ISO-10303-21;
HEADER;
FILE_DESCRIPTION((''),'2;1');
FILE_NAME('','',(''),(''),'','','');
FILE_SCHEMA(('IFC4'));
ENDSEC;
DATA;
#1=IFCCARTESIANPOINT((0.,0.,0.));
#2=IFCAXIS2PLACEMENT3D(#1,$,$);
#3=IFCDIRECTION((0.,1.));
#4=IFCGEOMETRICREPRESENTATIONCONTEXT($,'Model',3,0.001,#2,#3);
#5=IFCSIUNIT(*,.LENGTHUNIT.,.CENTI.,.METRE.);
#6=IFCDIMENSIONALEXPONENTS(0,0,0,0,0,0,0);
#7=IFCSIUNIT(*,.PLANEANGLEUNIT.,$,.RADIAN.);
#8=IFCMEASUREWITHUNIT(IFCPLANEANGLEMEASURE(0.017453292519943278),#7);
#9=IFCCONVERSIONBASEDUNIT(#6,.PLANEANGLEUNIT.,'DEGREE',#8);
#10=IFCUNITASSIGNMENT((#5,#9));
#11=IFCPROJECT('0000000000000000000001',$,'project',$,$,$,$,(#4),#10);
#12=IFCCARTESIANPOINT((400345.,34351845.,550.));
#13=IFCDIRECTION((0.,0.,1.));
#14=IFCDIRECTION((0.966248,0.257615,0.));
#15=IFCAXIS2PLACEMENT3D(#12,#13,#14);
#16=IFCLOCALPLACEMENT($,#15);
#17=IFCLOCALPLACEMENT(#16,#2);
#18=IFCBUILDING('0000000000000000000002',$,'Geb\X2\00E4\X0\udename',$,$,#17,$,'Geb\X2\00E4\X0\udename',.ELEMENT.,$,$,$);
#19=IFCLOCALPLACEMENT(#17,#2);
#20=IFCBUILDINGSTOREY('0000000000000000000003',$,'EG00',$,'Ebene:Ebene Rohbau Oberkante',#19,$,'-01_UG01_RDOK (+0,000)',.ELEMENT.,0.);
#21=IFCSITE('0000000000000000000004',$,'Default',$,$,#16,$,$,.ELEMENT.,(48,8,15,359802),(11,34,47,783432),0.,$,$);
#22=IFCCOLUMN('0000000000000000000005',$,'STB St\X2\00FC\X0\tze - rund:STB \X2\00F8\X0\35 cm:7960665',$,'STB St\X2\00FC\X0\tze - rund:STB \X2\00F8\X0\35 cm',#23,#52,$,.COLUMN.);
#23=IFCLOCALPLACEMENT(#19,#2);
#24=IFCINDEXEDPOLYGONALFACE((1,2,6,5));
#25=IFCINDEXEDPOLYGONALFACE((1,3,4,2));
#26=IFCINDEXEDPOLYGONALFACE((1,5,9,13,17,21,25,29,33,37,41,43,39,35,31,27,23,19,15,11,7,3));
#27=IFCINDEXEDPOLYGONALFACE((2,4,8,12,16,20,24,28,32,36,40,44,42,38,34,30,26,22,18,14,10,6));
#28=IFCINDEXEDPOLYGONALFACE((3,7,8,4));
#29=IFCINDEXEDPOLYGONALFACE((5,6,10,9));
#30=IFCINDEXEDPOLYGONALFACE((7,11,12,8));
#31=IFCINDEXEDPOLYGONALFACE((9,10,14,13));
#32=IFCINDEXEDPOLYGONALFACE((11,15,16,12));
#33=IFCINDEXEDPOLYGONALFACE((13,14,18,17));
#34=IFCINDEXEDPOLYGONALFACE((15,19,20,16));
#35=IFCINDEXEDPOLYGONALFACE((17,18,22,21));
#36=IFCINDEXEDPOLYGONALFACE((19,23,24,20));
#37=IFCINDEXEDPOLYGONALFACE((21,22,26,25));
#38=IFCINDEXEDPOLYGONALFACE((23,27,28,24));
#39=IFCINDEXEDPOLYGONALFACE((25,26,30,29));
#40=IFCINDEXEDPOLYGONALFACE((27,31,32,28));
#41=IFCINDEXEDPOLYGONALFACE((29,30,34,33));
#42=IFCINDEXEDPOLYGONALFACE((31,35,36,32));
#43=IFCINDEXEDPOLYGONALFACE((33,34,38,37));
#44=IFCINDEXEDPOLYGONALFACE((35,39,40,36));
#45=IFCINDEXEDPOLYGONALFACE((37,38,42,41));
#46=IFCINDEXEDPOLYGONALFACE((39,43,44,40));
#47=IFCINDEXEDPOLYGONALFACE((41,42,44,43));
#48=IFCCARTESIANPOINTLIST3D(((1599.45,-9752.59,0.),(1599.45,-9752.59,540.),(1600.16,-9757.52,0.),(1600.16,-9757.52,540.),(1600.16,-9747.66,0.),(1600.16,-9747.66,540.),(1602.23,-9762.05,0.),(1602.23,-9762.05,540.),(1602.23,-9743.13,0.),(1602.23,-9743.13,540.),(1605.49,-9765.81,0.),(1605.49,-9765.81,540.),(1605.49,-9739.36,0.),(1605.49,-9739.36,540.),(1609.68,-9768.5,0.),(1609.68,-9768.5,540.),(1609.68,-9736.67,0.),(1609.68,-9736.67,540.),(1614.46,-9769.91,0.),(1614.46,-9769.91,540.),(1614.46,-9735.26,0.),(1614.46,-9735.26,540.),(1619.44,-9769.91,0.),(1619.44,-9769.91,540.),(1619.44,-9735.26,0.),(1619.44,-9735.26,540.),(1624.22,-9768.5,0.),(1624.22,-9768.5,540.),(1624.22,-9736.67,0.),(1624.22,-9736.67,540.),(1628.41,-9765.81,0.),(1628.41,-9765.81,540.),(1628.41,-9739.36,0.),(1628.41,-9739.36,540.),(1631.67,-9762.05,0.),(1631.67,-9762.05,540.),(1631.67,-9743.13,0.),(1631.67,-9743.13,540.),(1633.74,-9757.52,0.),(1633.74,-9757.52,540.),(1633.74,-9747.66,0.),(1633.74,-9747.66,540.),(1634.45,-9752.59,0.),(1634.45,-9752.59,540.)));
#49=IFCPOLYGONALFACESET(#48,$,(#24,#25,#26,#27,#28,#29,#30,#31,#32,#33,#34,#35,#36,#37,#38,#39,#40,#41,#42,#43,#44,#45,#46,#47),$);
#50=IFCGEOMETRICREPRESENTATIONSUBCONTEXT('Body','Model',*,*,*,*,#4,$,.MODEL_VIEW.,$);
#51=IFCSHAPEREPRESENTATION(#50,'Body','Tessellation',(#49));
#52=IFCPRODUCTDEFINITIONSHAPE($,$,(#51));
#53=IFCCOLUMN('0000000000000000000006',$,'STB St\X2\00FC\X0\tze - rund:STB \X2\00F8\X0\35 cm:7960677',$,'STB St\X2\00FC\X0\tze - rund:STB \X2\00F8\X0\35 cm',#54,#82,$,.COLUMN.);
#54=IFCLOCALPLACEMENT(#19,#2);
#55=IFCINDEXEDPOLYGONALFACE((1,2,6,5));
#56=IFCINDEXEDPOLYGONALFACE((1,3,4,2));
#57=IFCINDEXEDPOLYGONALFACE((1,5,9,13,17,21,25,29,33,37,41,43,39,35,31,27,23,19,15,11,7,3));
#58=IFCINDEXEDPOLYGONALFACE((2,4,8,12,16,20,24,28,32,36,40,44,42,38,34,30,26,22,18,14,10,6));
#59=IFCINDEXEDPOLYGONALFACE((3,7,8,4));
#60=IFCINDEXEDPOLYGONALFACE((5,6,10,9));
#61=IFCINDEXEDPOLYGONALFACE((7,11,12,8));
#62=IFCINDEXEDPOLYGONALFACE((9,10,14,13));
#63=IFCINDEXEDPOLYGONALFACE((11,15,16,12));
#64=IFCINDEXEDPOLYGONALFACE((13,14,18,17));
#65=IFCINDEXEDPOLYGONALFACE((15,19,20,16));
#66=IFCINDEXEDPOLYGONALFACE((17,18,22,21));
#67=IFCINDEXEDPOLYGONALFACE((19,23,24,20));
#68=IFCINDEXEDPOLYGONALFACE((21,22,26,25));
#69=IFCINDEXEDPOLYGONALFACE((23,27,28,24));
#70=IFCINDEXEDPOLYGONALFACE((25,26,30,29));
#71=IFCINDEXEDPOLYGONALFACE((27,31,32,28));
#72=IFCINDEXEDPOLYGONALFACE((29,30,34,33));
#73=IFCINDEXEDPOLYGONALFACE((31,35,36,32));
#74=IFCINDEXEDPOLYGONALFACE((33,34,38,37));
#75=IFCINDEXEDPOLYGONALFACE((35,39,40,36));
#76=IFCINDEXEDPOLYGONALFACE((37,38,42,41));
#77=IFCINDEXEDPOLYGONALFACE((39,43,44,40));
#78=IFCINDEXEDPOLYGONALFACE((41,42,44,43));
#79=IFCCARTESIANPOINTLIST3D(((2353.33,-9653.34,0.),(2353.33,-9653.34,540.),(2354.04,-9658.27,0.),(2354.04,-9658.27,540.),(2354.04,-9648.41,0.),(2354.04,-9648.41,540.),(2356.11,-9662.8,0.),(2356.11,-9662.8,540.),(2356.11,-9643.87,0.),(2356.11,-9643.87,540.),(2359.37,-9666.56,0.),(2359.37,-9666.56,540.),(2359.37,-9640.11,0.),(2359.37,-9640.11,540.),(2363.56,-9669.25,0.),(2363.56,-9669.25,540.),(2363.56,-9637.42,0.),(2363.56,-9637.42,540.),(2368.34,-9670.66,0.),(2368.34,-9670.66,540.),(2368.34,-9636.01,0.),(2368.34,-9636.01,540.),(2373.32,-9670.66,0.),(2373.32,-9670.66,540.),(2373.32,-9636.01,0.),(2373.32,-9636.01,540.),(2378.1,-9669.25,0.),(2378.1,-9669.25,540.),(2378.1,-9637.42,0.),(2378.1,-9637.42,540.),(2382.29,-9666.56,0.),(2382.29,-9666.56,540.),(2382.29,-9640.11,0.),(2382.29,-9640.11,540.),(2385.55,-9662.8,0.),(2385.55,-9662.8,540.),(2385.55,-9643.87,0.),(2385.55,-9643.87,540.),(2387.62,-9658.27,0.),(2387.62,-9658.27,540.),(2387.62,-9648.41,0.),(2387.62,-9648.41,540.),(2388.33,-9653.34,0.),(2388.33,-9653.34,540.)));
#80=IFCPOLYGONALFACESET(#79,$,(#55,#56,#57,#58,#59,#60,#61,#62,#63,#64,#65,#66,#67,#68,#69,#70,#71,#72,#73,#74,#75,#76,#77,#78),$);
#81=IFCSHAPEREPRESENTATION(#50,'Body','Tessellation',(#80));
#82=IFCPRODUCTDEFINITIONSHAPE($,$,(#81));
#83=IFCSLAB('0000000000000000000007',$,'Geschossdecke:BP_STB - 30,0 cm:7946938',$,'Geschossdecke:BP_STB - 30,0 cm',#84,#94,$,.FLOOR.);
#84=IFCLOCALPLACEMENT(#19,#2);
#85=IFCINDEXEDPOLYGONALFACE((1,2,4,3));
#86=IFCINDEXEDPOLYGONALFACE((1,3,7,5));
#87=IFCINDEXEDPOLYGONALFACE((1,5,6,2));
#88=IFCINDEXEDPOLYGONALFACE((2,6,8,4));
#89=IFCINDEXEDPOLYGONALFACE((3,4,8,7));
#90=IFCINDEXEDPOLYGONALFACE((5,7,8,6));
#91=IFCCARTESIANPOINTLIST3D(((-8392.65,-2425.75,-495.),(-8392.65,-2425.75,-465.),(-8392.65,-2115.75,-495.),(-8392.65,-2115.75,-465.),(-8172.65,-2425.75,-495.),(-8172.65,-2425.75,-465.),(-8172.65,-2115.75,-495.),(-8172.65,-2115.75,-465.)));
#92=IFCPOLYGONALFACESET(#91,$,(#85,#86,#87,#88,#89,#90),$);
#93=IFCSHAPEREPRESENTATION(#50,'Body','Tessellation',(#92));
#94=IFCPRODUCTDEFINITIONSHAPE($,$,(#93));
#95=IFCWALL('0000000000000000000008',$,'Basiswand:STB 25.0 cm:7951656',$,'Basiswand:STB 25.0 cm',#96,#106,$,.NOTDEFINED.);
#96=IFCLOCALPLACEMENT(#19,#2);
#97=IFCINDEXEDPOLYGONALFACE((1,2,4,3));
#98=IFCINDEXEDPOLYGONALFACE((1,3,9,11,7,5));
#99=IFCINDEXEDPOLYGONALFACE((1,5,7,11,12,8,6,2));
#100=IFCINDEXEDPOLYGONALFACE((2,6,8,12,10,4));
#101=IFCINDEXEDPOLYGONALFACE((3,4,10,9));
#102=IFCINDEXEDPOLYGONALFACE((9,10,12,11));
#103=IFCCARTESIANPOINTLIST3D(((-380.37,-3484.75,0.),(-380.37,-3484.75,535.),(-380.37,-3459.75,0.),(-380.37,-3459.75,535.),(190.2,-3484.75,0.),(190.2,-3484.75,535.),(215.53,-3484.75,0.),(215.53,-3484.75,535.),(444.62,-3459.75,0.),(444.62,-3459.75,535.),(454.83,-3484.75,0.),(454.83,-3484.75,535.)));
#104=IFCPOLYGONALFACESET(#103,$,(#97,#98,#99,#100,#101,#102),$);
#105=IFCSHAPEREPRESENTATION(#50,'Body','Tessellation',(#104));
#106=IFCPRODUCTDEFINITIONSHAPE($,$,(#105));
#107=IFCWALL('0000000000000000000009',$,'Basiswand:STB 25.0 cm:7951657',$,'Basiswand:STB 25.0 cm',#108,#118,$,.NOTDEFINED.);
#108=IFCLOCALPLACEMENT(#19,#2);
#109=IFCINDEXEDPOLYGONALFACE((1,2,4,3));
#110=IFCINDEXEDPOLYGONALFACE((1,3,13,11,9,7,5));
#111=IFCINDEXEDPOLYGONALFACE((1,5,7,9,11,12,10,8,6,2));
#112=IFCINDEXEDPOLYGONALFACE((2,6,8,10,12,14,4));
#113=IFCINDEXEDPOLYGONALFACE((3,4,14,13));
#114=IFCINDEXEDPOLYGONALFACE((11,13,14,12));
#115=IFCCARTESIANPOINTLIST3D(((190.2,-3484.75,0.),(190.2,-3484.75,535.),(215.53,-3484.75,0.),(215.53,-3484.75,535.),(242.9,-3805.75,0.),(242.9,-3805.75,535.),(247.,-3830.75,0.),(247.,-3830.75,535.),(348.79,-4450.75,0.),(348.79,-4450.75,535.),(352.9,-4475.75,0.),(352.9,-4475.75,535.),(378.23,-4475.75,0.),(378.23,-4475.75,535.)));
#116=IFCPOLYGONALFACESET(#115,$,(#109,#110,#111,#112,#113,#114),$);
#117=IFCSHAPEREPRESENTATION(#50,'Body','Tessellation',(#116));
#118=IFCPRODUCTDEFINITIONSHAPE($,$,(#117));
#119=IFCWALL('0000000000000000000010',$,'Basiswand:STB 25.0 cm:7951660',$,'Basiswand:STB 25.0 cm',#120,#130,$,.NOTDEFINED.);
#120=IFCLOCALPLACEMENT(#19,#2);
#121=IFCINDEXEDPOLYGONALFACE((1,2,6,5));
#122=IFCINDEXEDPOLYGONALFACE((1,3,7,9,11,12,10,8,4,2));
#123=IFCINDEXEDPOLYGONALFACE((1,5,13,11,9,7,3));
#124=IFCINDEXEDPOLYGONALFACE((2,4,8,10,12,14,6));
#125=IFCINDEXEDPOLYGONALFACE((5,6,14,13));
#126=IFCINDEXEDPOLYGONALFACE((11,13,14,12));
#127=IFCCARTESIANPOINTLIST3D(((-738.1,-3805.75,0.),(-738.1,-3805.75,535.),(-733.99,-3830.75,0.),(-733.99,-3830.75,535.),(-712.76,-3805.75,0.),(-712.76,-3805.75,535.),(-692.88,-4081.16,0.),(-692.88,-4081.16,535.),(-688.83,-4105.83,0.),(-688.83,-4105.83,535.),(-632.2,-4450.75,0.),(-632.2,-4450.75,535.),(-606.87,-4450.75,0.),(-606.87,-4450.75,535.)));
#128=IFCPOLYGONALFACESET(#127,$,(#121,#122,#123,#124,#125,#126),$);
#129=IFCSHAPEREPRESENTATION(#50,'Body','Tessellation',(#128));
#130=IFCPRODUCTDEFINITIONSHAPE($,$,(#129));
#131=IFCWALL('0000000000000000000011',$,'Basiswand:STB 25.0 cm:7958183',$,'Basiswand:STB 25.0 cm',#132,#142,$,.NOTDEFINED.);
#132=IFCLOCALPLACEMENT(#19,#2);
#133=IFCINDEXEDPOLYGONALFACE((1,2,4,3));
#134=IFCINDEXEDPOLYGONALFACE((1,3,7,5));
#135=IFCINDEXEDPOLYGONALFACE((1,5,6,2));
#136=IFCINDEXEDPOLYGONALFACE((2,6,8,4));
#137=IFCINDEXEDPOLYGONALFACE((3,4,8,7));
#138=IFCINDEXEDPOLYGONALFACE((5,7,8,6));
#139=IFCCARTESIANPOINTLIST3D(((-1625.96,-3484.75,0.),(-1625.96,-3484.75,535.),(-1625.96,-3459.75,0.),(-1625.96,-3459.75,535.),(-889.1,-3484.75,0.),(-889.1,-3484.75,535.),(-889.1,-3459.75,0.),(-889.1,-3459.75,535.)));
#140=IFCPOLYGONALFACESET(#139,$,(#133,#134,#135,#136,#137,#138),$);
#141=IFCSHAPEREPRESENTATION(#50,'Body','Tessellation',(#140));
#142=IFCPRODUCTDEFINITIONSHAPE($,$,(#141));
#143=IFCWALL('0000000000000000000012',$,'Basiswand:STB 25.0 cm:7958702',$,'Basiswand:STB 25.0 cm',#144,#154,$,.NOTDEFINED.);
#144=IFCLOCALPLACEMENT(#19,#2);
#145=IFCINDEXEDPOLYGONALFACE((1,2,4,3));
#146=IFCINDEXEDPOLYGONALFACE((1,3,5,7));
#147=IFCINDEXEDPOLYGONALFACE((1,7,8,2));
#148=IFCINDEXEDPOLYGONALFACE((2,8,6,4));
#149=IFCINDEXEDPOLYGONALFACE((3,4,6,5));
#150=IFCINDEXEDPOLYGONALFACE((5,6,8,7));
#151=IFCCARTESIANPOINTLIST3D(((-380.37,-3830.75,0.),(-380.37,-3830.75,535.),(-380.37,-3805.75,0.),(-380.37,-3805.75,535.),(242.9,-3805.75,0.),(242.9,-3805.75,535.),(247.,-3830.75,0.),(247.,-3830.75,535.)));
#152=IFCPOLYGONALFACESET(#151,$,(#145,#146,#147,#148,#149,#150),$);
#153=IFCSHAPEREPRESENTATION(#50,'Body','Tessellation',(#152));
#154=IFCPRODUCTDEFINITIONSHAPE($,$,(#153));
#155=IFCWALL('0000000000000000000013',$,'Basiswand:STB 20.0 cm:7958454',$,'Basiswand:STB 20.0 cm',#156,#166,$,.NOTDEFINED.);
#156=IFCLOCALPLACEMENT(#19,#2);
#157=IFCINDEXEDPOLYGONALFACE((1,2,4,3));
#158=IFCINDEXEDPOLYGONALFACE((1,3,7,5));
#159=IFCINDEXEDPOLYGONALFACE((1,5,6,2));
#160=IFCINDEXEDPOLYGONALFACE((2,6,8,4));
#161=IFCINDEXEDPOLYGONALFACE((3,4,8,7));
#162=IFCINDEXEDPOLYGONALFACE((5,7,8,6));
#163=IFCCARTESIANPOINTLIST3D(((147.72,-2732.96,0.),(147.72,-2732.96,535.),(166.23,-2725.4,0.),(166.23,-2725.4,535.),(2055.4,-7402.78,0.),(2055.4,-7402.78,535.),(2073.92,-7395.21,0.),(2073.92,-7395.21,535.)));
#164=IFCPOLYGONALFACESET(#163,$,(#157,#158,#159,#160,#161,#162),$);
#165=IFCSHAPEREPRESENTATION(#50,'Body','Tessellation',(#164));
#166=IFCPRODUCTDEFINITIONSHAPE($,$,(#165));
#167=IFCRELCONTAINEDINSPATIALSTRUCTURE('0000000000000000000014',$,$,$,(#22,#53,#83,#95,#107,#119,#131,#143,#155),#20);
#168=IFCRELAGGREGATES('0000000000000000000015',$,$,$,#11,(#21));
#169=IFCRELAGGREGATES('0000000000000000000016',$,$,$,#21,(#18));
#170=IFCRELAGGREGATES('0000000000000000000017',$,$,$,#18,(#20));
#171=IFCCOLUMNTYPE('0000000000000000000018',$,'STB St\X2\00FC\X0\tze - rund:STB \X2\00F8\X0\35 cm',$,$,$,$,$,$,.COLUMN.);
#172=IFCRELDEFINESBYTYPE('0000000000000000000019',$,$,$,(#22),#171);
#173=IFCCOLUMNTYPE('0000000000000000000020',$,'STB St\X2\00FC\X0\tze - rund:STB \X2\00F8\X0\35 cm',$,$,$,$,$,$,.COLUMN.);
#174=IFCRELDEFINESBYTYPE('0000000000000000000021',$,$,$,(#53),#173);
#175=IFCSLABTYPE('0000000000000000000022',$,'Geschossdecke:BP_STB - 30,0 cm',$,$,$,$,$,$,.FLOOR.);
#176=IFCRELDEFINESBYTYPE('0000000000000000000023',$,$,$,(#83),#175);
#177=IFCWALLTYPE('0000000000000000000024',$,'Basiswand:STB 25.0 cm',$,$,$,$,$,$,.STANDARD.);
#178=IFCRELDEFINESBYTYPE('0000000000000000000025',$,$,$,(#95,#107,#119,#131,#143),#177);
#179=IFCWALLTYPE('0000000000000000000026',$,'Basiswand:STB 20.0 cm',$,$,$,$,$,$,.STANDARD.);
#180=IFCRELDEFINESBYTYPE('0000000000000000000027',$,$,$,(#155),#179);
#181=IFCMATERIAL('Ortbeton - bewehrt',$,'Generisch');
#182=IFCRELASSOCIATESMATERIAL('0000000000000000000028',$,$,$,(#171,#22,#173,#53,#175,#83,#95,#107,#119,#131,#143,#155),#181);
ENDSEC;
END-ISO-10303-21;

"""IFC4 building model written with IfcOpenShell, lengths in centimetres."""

from ifc_helpers import new_model, entity, si_unit, converted_unit, direction, frame, origin, place, context, subcontext, project, spatial, arc, indexed_curve, outline, extrude, source, transform, mapped, material, type_object, type_shapes, element, save


model = new_model("IFC4")

# Units and contexts
model_context = context("Model", 3, precision=0.001, world=origin(), true_north=direction((0.0, 1.0)))
body_context = subcontext(model_context, "Body", "Model", "MODEL_VIEW")
ifc_project = project(units=[si_unit("LENGTHUNIT", "METRE", prefix="CENTI"), converted_unit("PLANEANGLEUNIT", "DEGREE", entity("IfcPlaneAngleMeasure", 0.017453292519943278), si_unit("PLANEANGLEUNIT", "RADIAN"), dimensions=[0, 0, 0, 0, 0, 0, 0])], contexts=[model_context])

# Site, building, storey
site_placement = place(None, frame((400345.0, 34351845.0, 550.0), z_axis=(0.0, 0.0, 1.0), x_axis=(0.966248, 0.257615, 0.0)))
site = spatial("IfcSite", under=ifc_project, at=site_placement, Name="Default", CompositionType="ELEMENT", RefLatitude=(48, 8, 15, 359802), RefLongitude=(11, 34, 47, 783432), RefElevation=0.0)
building_placement = place(site_placement, origin())
building = spatial("IfcBuilding", under=site, at=building_placement, Name="Gebäudename", LongName="Gebäudename", CompositionType="ELEMENT")
storey_placement = place(building_placement, origin())
storey = spatial("IfcBuildingStorey", under=building, at=storey_placement, Name="EG00", ObjectType="Ebene:Ebene Rohbau Oberkante", LongName="-01_UG01_RDOK (+0,000)", CompositionType="ELEMENT", Elevation=0.0)

# Columns
ifc_material = material(Name="Ortbeton - bewehrt", Category="Generisch")
column_type_1 = type_object("IfcColumnType", Name="STB Stütze - rund:STB ø35 cm", PredefinedType="COLUMN", material=ifc_material)
shared_shape_1 = source(origin(), body_context, "Body", "SweptSolid", [
    extrude(outline(indexed_curve([(-17.5, 0.0), (0.0, -17.5), (17.5, 0.0), (0.0, 17.5)], segments=[arc(1, 2, 3), arc(3, 4, 1)], self_intersect=False)), frame((1616.95, -9752.59, 0.0)), (0.0, 0.0, 1.0), 540.0),
])
type_shapes(column_type_1, [shared_shape_1])
column_1_placement = place(storey_placement, origin())
element("IfcColumn", 1, at=column_1_placement, inside=storey, type_object=column_type_1, material=ifc_material, Name="STB Stütze - rund:STB ø35 cm:7960665", ObjectType="STB Stütze - rund:STB ø35 cm", PredefinedType="COLUMN", context=body_context, shape_type="MappedRepresentation", body=[
    mapped(shared_shape_1, transform((0.0, 0.0, 0.0), scale=1.0)),
])
column_type_2 = type_object("IfcColumnType", Name="STB Stütze - rund:STB ø35 cm", PredefinedType="COLUMN", material=ifc_material)
shared_shape_2 = source(origin(), body_context, "Body", "SweptSolid", [
    extrude(outline(indexed_curve([(-17.5, 0.0), (0.0, -17.5), (17.5, 0.0), (0.0, 17.5)], segments=[arc(1, 2, 3), arc(3, 4, 1)], self_intersect=False)), frame((2370.83, -9653.34, 0.0)), (0.0, 0.0, 1.0), 540.0),
])
type_shapes(column_type_2, [shared_shape_2])
column_2_placement = place(storey_placement, origin())
element("IfcColumn", 2, at=column_2_placement, inside=storey, type_object=column_type_2, material=ifc_material, Name="STB Stütze - rund:STB ø35 cm:7960677", ObjectType="STB Stütze - rund:STB ø35 cm", PredefinedType="COLUMN", context=body_context, shape_type="MappedRepresentation", body=[
    mapped(shared_shape_2, transform((0.0, 0.0, 0.0), scale=1.0)),
])

# Slab
slab_type_1 = type_object("IfcSlabType", Name="Geschossdecke:BP_STB - 30,0 cm", PredefinedType="FLOOR", material=ifc_material)
slab_1_placement = place(storey_placement, origin())
element("IfcSlab", 3, at=slab_1_placement, inside=storey, type_object=slab_type_1, material=ifc_material, Name="Geschossdecke:BP_STB - 30,0 cm:7946938", ObjectType="Geschossdecke:BP_STB - 30,0 cm", PredefinedType="FLOOR", context=body_context, shape_type="SweptSolid", body=[
    extrude(outline(indexed_curve([(-155.0, -110.0), (155.0, -110.0), (155.0, 110.0), (-155.0, 110.0), (-155.0, -110.0)], self_intersect=False)), frame((-8282.65, -2270.75, -465.0), z_axis=(0.0, 0.0, -1.0), x_axis=(0.0, 1.0, 0.0)), (0.0, 0.0, 1.0), 30.0),
])

# Walls
wall_type_1 = type_object("IfcWallType", Name="Basiswand:STB 25.0 cm", PredefinedType="STANDARD")
wall_1_placement = place(storey_placement, frame((-380.37, -3472.25, 0.0)))
element("IfcWall", 4, at=wall_1_placement, inside=storey, type_object=wall_type_1, material=ifc_material, Name="Basiswand:STB 25.0 cm:7951656", ObjectType="Basiswand:STB 25.0 cm", PredefinedType="NOTDEFINED", context=body_context, shape_type="SweptSolid", body=[
    extrude(outline(indexed_curve([(835.2, -12.5), (824.99, 12.5), (0.0, 12.5), (0.0, -12.5), (570.57, -12.5), (595.9, -12.5), (835.2, -12.5)], self_intersect=False)), origin(), (0.0, 0.0, 1.0), 535.0),
])
wall_2_placement = place(storey_placement, frame((202.53, -3482.72, 0.0), z_axis=(0.0, 0.0, 1.0), x_axis=(0.162011, -0.986789, 0.0)))
element("IfcWall", 5, at=wall_2_placement, inside=storey, type_object=wall_type_1, material=ifc_material, Name="Basiswand:STB 25.0 cm:7951657", ObjectType="Basiswand:STB 25.0 cm", PredefinedType="NOTDEFINED", context=body_context, shape_type="SweptSolid", body=[
    extrude(outline(indexed_curve([(1004.27, -12.5), (1008.37, 12.5), (4.1, 12.5), (0.0, -12.5), (325.3, -12.5), (350.63, -12.5), (978.93, -12.5), (1004.27, -12.5)], self_intersect=False)), origin(), (0.0, 0.0, 1.0), 535.0),
])
wall_3_placement = place(storey_placement, frame((-725.76, -3803.72, 0.0), z_axis=(0.0, 0.0, 1.0), x_axis=(0.162011, -0.986789, 0.0)))
element("IfcWall", 6, at=wall_3_placement, inside=storey, type_object=wall_type_1, material=ifc_material, Name="Basiswand:STB 25.0 cm:7951660", ObjectType="Basiswand:STB 25.0 cm", PredefinedType="NOTDEFINED", context=body_context, shape_type="SweptSolid", body=[
    extrude(outline(indexed_curve([(653.64, -12.5), (657.74, 12.5), (4.1, 12.5), (0.0, -12.5), (25.33, -12.5), (279.1, -12.5), (304.1, -12.5), (653.64, -12.5)], self_intersect=False)), origin(), (0.0, 0.0, 1.0), 535.0),
])
wall_4_placement = place(storey_placement, frame((-1625.96, -3472.25, 0.0)))
element("IfcWall", 7, at=wall_4_placement, inside=storey, type_object=wall_type_1, material=ifc_material, Name="Basiswand:STB 25.0 cm:7958183", ObjectType="Basiswand:STB 25.0 cm", PredefinedType="NOTDEFINED", context=body_context, shape_type="SweptSolid", body=[
    extrude(outline(indexed_curve([(736.86, 12.5), (0.0, 12.5), (0.0, -12.5), (736.86, -12.5), (736.86, 12.5)], self_intersect=False)), origin(), (0.0, 0.0, 1.0), 535.0),
])
wall_5_placement = place(storey_placement, frame((-380.37, -3818.25, 0.0)))
element("IfcWall", 8, at=wall_5_placement, inside=storey, type_object=wall_type_1, material=ifc_material, Name="Basiswand:STB 25.0 cm:7958702", ObjectType="Basiswand:STB 25.0 cm", PredefinedType="NOTDEFINED", context=body_context, shape_type="SweptSolid", body=[
    extrude(outline(indexed_curve([(627.37, -12.5), (623.27, 12.5), (0.0, 12.5), (0.0, -12.5), (627.37, -12.5)], self_intersect=False)), origin(), (0.0, 0.0, 1.0), 535.0),
])
wall_type_2 = type_object("IfcWallType", Name="Basiswand:STB 20.0 cm", PredefinedType="STANDARD")
wall_6_placement = place(storey_placement, frame((156.97, -2729.18, 0.0), z_axis=(0.0, 0.0, 1.0), x_axis=(0.378175, -0.925734, 0.0)))
element("IfcWall", 9, at=wall_6_placement, inside=storey, type_object=wall_type_2, material=ifc_material, Name="Basiswand:STB 20.0 cm:7958454", ObjectType="Basiswand:STB 20.0 cm", PredefinedType="NOTDEFINED", context=body_context, shape_type="SweptSolid", body=[
    extrude(outline(indexed_curve([(5044.45, 10.0), (0.0, 10.0), (0.0, -10.0), (5044.45, -10.0), (5044.45, 10.0)], self_intersect=False)), origin(), (0.0, 0.0, 1.0), 535.0),
])

save(model, "model.ifc")
